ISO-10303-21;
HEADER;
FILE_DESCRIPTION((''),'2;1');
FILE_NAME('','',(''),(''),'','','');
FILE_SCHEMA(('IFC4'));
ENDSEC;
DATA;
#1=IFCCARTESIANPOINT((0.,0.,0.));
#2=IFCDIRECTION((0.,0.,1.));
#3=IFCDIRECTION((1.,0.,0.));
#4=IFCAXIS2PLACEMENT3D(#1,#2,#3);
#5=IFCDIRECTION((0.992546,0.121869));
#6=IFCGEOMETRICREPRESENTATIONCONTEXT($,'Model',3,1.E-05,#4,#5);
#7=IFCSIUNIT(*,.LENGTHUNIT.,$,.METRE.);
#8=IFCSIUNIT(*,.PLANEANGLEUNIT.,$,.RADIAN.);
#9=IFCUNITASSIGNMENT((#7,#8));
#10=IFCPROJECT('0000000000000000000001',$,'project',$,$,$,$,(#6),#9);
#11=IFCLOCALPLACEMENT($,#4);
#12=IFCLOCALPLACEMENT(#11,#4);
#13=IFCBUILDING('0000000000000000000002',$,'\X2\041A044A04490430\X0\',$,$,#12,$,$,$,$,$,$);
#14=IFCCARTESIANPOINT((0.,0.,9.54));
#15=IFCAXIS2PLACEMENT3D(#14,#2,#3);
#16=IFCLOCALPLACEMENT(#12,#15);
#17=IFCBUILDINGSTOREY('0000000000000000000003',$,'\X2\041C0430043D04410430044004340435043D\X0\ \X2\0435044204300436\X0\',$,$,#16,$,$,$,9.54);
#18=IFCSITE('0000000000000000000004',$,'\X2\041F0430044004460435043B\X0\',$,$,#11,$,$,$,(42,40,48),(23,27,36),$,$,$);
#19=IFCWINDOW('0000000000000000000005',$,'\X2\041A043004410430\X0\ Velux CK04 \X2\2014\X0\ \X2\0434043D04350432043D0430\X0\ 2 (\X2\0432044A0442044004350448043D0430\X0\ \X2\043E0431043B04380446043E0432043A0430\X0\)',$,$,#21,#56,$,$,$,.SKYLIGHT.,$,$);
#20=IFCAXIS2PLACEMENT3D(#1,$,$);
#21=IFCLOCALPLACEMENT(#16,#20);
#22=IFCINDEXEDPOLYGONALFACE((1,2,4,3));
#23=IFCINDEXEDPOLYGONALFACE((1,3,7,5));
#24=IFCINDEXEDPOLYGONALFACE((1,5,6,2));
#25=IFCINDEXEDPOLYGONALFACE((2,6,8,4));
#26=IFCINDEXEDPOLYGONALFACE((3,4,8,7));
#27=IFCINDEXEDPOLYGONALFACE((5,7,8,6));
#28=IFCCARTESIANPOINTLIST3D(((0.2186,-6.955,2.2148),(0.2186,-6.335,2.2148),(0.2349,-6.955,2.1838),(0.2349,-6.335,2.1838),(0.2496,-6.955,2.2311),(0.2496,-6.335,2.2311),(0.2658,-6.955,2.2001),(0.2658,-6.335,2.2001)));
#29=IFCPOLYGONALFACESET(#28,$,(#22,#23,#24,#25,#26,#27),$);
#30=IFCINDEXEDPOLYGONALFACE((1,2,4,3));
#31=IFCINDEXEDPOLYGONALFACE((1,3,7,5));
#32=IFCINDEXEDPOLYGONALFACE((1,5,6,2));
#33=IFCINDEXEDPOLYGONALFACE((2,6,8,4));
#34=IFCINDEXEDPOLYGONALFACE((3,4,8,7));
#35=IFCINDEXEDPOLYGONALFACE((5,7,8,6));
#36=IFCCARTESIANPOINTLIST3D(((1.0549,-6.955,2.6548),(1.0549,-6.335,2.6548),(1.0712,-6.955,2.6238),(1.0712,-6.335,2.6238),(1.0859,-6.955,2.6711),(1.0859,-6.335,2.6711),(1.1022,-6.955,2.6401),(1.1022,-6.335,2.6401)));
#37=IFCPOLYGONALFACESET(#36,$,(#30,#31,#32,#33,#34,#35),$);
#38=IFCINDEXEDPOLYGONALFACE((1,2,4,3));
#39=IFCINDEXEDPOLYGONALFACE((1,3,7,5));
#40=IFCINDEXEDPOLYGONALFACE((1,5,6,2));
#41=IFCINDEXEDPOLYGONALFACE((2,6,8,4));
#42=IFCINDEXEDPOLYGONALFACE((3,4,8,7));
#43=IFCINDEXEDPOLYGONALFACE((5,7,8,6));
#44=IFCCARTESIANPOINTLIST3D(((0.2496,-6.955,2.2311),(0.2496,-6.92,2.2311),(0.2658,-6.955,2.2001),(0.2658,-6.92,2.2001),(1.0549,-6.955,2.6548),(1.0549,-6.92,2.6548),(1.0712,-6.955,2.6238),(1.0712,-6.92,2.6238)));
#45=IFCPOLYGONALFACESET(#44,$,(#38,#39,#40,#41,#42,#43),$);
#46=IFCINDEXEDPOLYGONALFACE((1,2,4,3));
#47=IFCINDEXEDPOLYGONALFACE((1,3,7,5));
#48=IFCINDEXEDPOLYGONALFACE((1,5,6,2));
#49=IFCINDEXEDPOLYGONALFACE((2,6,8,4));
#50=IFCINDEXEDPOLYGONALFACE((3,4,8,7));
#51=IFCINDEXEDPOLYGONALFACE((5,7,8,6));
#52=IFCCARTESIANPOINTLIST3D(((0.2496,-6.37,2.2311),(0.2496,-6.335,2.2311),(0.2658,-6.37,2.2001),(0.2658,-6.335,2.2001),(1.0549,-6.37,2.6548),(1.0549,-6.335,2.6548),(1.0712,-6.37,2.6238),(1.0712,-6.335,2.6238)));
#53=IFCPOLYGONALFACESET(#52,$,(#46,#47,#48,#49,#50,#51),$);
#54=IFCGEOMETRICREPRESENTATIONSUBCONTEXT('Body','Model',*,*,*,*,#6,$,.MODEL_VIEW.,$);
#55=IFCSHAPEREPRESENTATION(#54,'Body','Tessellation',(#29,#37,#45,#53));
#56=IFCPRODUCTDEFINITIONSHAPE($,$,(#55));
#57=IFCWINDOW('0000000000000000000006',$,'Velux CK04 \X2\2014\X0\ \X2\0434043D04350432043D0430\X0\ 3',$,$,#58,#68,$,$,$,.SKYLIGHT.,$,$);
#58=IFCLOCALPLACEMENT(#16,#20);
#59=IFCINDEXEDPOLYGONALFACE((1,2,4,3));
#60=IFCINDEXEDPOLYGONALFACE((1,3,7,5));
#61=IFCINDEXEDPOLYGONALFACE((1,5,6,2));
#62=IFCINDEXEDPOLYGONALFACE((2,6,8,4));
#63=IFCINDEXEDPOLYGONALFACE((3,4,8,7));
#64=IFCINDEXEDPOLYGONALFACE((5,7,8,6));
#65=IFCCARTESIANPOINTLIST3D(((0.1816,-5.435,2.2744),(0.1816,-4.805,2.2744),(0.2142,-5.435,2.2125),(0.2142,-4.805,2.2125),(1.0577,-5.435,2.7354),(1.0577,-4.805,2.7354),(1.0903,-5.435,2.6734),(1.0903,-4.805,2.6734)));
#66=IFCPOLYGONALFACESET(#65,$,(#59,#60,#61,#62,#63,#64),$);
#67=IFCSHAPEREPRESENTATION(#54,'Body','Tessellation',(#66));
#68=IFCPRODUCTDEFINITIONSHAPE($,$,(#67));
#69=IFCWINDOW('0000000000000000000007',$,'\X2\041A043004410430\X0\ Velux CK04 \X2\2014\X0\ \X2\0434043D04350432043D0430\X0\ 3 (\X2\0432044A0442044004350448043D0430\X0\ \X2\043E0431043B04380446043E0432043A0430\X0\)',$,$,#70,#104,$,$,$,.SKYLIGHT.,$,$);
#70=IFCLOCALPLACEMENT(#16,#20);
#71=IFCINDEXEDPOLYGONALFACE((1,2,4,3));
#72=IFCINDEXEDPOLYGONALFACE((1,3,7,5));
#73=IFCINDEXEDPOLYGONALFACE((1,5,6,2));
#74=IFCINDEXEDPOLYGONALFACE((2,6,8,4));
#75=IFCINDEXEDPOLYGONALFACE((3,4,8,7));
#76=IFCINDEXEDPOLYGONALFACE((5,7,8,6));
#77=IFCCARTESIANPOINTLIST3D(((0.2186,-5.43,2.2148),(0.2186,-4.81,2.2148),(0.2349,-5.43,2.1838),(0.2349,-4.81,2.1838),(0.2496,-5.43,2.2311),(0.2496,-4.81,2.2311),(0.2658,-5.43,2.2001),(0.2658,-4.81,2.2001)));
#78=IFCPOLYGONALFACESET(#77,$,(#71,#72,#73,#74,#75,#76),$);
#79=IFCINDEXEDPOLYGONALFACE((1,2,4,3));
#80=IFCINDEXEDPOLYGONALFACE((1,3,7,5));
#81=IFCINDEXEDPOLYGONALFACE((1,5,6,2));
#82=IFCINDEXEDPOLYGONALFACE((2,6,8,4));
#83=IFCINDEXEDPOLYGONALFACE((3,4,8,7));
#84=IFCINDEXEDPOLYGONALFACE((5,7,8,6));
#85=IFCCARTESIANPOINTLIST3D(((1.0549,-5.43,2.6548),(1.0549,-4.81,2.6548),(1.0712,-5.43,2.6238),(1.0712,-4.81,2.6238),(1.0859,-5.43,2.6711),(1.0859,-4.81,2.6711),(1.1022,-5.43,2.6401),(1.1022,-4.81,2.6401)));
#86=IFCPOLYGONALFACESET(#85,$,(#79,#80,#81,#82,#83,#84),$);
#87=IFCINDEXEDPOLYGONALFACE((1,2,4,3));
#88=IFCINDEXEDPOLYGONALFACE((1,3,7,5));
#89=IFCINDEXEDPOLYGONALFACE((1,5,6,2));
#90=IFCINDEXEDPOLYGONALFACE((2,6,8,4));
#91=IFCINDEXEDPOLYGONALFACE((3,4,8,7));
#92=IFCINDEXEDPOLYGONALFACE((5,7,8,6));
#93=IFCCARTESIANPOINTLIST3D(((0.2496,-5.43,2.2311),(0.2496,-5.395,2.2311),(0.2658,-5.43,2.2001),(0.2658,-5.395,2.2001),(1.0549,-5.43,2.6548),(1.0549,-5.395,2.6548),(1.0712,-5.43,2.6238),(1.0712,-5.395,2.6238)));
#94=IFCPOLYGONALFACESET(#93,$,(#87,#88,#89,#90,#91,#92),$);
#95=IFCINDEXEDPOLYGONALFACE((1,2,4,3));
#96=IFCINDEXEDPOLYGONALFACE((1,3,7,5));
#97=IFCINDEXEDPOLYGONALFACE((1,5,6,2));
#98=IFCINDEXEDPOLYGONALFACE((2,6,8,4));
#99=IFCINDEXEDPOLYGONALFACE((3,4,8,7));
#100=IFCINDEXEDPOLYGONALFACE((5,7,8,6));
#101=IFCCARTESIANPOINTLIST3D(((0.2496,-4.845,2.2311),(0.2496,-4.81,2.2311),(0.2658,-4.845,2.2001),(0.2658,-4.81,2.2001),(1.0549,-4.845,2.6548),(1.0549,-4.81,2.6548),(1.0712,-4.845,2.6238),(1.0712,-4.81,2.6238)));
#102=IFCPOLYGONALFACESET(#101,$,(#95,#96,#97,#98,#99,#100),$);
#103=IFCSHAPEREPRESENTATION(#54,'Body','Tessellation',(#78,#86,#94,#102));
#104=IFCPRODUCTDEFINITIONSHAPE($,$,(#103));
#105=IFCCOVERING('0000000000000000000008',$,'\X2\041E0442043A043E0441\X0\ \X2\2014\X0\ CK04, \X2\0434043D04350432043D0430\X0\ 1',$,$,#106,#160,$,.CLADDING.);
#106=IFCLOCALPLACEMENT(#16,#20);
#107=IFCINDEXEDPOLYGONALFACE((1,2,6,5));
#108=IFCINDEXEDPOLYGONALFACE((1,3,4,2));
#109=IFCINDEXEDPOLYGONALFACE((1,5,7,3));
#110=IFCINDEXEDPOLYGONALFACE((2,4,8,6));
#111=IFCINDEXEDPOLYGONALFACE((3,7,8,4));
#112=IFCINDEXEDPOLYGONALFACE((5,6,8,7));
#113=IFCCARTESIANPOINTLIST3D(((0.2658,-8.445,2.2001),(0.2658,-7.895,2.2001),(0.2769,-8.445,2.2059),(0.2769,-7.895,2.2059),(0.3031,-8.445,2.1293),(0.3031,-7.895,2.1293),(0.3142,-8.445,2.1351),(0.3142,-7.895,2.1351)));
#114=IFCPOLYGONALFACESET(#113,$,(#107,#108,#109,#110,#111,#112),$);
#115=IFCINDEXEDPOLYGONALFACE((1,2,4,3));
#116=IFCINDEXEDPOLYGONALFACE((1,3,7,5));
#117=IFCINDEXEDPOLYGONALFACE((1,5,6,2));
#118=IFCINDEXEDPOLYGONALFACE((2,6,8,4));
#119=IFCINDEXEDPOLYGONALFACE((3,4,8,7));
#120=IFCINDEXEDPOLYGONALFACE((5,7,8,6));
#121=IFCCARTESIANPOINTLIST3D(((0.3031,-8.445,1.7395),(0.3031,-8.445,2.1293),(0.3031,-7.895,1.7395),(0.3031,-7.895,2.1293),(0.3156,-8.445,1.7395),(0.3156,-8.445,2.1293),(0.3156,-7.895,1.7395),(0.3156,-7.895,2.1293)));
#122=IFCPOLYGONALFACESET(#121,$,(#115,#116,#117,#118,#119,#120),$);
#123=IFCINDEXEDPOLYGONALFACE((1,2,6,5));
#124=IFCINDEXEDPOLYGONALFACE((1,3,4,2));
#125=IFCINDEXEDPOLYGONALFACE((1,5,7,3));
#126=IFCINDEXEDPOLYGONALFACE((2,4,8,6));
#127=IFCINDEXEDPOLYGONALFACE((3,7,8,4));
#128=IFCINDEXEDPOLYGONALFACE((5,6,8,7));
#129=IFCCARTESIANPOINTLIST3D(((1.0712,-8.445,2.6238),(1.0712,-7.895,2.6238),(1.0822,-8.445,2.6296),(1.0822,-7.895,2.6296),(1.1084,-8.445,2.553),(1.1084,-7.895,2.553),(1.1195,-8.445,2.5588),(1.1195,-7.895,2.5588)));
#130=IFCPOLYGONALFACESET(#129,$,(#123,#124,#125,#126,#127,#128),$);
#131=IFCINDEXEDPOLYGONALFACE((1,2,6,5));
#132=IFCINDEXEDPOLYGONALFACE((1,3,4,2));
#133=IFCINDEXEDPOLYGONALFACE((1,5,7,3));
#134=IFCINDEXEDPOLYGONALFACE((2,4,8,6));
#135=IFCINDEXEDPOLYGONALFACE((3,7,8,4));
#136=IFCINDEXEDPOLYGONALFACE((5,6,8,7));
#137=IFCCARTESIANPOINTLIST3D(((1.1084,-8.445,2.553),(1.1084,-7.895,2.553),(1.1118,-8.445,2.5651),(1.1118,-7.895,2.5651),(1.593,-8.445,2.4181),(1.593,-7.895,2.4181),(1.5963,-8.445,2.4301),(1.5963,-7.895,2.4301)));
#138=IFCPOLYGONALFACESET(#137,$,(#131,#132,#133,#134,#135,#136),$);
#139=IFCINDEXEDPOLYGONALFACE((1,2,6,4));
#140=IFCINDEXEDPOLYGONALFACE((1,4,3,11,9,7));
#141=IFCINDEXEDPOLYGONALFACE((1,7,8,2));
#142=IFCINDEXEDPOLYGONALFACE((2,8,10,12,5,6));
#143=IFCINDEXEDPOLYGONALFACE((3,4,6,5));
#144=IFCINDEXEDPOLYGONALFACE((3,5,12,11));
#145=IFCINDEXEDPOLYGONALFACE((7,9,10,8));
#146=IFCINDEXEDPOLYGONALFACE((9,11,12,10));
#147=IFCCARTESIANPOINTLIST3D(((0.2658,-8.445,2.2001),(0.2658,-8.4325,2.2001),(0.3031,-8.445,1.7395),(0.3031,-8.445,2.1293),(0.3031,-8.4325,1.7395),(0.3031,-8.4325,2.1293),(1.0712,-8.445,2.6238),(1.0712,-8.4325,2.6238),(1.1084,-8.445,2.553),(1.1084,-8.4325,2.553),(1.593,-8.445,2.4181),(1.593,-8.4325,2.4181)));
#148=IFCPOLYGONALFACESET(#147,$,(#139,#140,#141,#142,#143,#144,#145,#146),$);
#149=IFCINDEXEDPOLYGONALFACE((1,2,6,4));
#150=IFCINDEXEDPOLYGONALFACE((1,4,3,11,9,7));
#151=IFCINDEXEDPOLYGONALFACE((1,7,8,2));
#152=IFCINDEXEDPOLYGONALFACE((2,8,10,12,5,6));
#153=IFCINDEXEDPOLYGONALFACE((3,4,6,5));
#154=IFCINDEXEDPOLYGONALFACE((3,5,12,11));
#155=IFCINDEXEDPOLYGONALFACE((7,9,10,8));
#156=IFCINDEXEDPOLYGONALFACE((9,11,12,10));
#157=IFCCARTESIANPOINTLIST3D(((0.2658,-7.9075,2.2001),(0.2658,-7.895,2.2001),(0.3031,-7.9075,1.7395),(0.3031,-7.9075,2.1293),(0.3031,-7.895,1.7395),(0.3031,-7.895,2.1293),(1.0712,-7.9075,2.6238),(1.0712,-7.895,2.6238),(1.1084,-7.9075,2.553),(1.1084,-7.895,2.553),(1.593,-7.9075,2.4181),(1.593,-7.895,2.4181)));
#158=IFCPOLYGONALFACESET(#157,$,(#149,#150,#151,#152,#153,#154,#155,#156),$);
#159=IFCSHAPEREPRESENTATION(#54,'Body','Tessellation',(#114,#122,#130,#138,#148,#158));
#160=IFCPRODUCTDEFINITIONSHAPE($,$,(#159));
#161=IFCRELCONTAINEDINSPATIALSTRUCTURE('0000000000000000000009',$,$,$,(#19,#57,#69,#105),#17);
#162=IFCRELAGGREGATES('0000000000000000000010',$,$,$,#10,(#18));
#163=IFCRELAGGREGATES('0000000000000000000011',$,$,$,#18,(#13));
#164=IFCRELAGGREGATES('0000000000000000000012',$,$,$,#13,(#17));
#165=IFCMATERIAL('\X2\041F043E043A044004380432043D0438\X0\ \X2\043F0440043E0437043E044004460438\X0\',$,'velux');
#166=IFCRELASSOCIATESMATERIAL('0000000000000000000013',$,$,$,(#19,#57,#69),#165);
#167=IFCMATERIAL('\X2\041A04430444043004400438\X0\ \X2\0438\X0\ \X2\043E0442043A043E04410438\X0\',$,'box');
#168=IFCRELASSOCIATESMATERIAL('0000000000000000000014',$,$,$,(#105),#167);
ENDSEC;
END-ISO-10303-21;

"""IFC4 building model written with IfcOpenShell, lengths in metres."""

from ifc_helpers import new_model, si_unit, direction, frame, origin_with_axes, place, context, subcontext, project, spatial, polyline, outline, extrude, material, element, save


model = new_model("IFC4")

# Units and contexts
model_context = context("Model", 3, precision=1e-05, world=origin_with_axes(), true_north=direction((0.992546, 0.121869)))
body_context = subcontext(model_context, "Body", "Model", "MODEL_VIEW")
ifc_project = project(units=[si_unit("LENGTHUNIT", "METRE"), si_unit("PLANEANGLEUNIT", "RADIAN")], contexts=[model_context])

# Site, building, storey
site_placement = place(None, origin_with_axes())
site = spatial("IfcSite", under=ifc_project, at=site_placement, Name="Парцел", RefLatitude=(42, 40, 48), RefLongitude=(23, 27, 36))
building_placement = place(site_placement, origin_with_axes())
building = spatial("IfcBuilding", under=site, at=building_placement, Name="Къща")
storey_placement = place(building_placement, frame((0.0, 0.0, 9.54), z_axis=(0.0, 0.0, 1.0), x_axis=(1.0, 0.0, 0.0)))
storey = spatial("IfcBuildingStorey", under=building, at=storey_placement, Name="Мансарден етаж", Elevation=9.54)

# Windows
ifc_material_1 = material(Name="Покривни прозорци", Category="velux")
window_1_placement = place(storey_placement, origin_with_axes())
element("IfcWindow", 1, at=window_1_placement, inside=storey, material=ifc_material_1, Name="Каса Velux CK04 — дневна 2 (вътрешна облицовка)", PredefinedType="SKYLIGHT", context=body_context, shape_type="SweptSolid", body=[
    extrude(outline(polyline([(0.2349, -2.1838), (0.2658, -2.2001), (0.2496, -2.2311), (0.2186, -2.2148), (0.2349, -2.1838)])), frame((0.0, -6.955, 0.0), z_axis=(0.0, 1.0, 0.0), x_axis=(1.0, 0.0, 0.0)), (0.0, 0.0, 1.0), 0.62),
    extrude(outline(polyline([(1.0712, -2.6238), (1.1022, -2.6401), (1.0859, -2.6711), (1.0549, -2.6548), (1.0712, -2.6238)])), frame((0.0, -6.955, 0.0), z_axis=(0.0, 1.0, 0.0), x_axis=(1.0, 0.0, 0.0)), (0.0, 0.0, 1.0), 0.62),
    extrude(outline(polyline([(0.2658, -2.2001), (1.0712, -2.6238), (1.0549, -2.6548), (0.2496, -2.2311), (0.2658, -2.2001)])), frame((0.0, -6.955, 0.0), z_axis=(0.0, 1.0, 0.0), x_axis=(1.0, 0.0, 0.0)), (0.0, 0.0, 1.0), 0.035),
    extrude(outline(polyline([(0.2658, -2.2001), (1.0712, -2.6238), (1.0549, -2.6548), (0.2496, -2.2311), (0.2658, -2.2001)])), frame((0.0, -6.37, 0.0), z_axis=(0.0, 1.0, 0.0), x_axis=(1.0, 0.0, 0.0)), (0.0, 0.0, 1.0), 0.035),
])
window_2_placement = place(storey_placement, origin_with_axes())
element("IfcWindow", 2, at=window_2_placement, inside=storey, material=ifc_material_1, Name="Velux CK04 — дневна 3", PredefinedType="SKYLIGHT", context=body_context, shape_type="SweptSolid", body=[
    extrude(outline(polyline([(0.2142, -2.2125), (1.0903, -2.6734), (1.0577, -2.7354), (0.1816, -2.2744), (0.2142, -2.2125)])), frame((0.0, -5.435, 0.0), z_axis=(0.0, 1.0, 0.0), x_axis=(1.0, 0.0, 0.0)), (0.0, 0.0, 1.0), 0.63),
])
window_3_placement = place(storey_placement, origin_with_axes())
element("IfcWindow", 3, at=window_3_placement, inside=storey, material=ifc_material_1, Name="Каса Velux CK04 — дневна 3 (вътрешна облицовка)", PredefinedType="SKYLIGHT", context=body_context, shape_type="SweptSolid", body=[
    extrude(outline(polyline([(0.2349, -2.1838), (0.2658, -2.2001), (0.2496, -2.2311), (0.2186, -2.2148), (0.2349, -2.1838)])), frame((0.0, -5.43, 0.0), z_axis=(0.0, 1.0, 0.0), x_axis=(1.0, 0.0, 0.0)), (0.0, 0.0, 1.0), 0.62),
    extrude(outline(polyline([(1.0712, -2.6238), (1.1022, -2.6401), (1.0859, -2.6711), (1.0549, -2.6548), (1.0712, -2.6238)])), frame((0.0, -5.43, 0.0), z_axis=(0.0, 1.0, 0.0), x_axis=(1.0, 0.0, 0.0)), (0.0, 0.0, 1.0), 0.62),
    extrude(outline(polyline([(0.2658, -2.2001), (1.0712, -2.6238), (1.0549, -2.6548), (0.2496, -2.2311), (0.2658, -2.2001)])), frame((0.0, -5.43, 0.0), z_axis=(0.0, 1.0, 0.0), x_axis=(1.0, 0.0, 0.0)), (0.0, 0.0, 1.0), 0.035),
    extrude(outline(polyline([(0.2658, -2.2001), (1.0712, -2.6238), (1.0549, -2.6548), (0.2496, -2.2311), (0.2658, -2.2001)])), frame((0.0, -4.845, 0.0), z_axis=(0.0, 1.0, 0.0), x_axis=(1.0, 0.0, 0.0)), (0.0, 0.0, 1.0), 0.035),
])

# Covering
ifc_material_2 = material(Name="Куфари и откоси", Category="box")
covering_1_placement = place(storey_placement, origin_with_axes())
element("IfcCovering", 4, at=covering_1_placement, inside=storey, material=ifc_material_2, Name="Откос — CK04, дневна 1", PredefinedType="CLADDING", context=body_context, shape_type="SweptSolid", body=[
    extrude(outline(polyline([(0.2658, -2.2001), (0.3031, -2.1293), (0.3142, -2.1351), (0.2769, -2.2059), (0.2658, -2.2001)])), frame((0.0, -8.445, 0.0), z_axis=(0.0, 1.0, 0.0), x_axis=(1.0, 0.0, 0.0)), (0.0, 0.0, 1.0), 0.55),
    extrude(outline(polyline([(0.3031, -2.1293), (0.3031, -1.7395), (0.3156, -1.7395), (0.3156, -2.1293), (0.3031, -2.1293)])), frame((0.0, -8.445, 0.0), z_axis=(0.0, 1.0, 0.0), x_axis=(1.0, 0.0, 0.0)), (0.0, 0.0, 1.0), 0.55),
    extrude(outline(polyline([(1.0712, -2.6238), (1.1084, -2.553), (1.1195, -2.5588), (1.0822, -2.6296), (1.0712, -2.6238)])), frame((0.0, -8.445, 0.0), z_axis=(0.0, 1.0, 0.0), x_axis=(1.0, 0.0, 0.0)), (0.0, 0.0, 1.0), 0.55),
    extrude(outline(polyline([(1.1084, -2.553), (1.593, -2.4181), (1.5963, -2.4301), (1.1118, -2.5651), (1.1084, -2.553)])), frame((0.0, -8.445, 0.0), z_axis=(0.0, 1.0, 0.0), x_axis=(1.0, 0.0, 0.0)), (0.0, 0.0, 1.0), 0.55),
    extrude(outline(polyline([(0.3031, -1.7395), (0.3031, -2.1293), (0.2658, -2.2001), (1.0712, -2.6238), (1.1084, -2.553), (1.593, -2.4181), (0.3031, -1.7395)])), frame((0.0, -8.445, 0.0), z_axis=(0.0, 1.0, 0.0), x_axis=(1.0, 0.0, 0.0)), (0.0, 0.0, 1.0), 0.0125),
    extrude(outline(polyline([(0.3031, -1.7395), (0.3031, -2.1293), (0.2658, -2.2001), (1.0712, -2.6238), (1.1084, -2.553), (1.593, -2.4181), (0.3031, -1.7395)])), frame((0.0, -7.9075, 0.0), z_axis=(0.0, 1.0, 0.0), x_axis=(1.0, 0.0, 0.0)), (0.0, 0.0, 1.0), 0.0125),
])

save(model, "model.ifc")
